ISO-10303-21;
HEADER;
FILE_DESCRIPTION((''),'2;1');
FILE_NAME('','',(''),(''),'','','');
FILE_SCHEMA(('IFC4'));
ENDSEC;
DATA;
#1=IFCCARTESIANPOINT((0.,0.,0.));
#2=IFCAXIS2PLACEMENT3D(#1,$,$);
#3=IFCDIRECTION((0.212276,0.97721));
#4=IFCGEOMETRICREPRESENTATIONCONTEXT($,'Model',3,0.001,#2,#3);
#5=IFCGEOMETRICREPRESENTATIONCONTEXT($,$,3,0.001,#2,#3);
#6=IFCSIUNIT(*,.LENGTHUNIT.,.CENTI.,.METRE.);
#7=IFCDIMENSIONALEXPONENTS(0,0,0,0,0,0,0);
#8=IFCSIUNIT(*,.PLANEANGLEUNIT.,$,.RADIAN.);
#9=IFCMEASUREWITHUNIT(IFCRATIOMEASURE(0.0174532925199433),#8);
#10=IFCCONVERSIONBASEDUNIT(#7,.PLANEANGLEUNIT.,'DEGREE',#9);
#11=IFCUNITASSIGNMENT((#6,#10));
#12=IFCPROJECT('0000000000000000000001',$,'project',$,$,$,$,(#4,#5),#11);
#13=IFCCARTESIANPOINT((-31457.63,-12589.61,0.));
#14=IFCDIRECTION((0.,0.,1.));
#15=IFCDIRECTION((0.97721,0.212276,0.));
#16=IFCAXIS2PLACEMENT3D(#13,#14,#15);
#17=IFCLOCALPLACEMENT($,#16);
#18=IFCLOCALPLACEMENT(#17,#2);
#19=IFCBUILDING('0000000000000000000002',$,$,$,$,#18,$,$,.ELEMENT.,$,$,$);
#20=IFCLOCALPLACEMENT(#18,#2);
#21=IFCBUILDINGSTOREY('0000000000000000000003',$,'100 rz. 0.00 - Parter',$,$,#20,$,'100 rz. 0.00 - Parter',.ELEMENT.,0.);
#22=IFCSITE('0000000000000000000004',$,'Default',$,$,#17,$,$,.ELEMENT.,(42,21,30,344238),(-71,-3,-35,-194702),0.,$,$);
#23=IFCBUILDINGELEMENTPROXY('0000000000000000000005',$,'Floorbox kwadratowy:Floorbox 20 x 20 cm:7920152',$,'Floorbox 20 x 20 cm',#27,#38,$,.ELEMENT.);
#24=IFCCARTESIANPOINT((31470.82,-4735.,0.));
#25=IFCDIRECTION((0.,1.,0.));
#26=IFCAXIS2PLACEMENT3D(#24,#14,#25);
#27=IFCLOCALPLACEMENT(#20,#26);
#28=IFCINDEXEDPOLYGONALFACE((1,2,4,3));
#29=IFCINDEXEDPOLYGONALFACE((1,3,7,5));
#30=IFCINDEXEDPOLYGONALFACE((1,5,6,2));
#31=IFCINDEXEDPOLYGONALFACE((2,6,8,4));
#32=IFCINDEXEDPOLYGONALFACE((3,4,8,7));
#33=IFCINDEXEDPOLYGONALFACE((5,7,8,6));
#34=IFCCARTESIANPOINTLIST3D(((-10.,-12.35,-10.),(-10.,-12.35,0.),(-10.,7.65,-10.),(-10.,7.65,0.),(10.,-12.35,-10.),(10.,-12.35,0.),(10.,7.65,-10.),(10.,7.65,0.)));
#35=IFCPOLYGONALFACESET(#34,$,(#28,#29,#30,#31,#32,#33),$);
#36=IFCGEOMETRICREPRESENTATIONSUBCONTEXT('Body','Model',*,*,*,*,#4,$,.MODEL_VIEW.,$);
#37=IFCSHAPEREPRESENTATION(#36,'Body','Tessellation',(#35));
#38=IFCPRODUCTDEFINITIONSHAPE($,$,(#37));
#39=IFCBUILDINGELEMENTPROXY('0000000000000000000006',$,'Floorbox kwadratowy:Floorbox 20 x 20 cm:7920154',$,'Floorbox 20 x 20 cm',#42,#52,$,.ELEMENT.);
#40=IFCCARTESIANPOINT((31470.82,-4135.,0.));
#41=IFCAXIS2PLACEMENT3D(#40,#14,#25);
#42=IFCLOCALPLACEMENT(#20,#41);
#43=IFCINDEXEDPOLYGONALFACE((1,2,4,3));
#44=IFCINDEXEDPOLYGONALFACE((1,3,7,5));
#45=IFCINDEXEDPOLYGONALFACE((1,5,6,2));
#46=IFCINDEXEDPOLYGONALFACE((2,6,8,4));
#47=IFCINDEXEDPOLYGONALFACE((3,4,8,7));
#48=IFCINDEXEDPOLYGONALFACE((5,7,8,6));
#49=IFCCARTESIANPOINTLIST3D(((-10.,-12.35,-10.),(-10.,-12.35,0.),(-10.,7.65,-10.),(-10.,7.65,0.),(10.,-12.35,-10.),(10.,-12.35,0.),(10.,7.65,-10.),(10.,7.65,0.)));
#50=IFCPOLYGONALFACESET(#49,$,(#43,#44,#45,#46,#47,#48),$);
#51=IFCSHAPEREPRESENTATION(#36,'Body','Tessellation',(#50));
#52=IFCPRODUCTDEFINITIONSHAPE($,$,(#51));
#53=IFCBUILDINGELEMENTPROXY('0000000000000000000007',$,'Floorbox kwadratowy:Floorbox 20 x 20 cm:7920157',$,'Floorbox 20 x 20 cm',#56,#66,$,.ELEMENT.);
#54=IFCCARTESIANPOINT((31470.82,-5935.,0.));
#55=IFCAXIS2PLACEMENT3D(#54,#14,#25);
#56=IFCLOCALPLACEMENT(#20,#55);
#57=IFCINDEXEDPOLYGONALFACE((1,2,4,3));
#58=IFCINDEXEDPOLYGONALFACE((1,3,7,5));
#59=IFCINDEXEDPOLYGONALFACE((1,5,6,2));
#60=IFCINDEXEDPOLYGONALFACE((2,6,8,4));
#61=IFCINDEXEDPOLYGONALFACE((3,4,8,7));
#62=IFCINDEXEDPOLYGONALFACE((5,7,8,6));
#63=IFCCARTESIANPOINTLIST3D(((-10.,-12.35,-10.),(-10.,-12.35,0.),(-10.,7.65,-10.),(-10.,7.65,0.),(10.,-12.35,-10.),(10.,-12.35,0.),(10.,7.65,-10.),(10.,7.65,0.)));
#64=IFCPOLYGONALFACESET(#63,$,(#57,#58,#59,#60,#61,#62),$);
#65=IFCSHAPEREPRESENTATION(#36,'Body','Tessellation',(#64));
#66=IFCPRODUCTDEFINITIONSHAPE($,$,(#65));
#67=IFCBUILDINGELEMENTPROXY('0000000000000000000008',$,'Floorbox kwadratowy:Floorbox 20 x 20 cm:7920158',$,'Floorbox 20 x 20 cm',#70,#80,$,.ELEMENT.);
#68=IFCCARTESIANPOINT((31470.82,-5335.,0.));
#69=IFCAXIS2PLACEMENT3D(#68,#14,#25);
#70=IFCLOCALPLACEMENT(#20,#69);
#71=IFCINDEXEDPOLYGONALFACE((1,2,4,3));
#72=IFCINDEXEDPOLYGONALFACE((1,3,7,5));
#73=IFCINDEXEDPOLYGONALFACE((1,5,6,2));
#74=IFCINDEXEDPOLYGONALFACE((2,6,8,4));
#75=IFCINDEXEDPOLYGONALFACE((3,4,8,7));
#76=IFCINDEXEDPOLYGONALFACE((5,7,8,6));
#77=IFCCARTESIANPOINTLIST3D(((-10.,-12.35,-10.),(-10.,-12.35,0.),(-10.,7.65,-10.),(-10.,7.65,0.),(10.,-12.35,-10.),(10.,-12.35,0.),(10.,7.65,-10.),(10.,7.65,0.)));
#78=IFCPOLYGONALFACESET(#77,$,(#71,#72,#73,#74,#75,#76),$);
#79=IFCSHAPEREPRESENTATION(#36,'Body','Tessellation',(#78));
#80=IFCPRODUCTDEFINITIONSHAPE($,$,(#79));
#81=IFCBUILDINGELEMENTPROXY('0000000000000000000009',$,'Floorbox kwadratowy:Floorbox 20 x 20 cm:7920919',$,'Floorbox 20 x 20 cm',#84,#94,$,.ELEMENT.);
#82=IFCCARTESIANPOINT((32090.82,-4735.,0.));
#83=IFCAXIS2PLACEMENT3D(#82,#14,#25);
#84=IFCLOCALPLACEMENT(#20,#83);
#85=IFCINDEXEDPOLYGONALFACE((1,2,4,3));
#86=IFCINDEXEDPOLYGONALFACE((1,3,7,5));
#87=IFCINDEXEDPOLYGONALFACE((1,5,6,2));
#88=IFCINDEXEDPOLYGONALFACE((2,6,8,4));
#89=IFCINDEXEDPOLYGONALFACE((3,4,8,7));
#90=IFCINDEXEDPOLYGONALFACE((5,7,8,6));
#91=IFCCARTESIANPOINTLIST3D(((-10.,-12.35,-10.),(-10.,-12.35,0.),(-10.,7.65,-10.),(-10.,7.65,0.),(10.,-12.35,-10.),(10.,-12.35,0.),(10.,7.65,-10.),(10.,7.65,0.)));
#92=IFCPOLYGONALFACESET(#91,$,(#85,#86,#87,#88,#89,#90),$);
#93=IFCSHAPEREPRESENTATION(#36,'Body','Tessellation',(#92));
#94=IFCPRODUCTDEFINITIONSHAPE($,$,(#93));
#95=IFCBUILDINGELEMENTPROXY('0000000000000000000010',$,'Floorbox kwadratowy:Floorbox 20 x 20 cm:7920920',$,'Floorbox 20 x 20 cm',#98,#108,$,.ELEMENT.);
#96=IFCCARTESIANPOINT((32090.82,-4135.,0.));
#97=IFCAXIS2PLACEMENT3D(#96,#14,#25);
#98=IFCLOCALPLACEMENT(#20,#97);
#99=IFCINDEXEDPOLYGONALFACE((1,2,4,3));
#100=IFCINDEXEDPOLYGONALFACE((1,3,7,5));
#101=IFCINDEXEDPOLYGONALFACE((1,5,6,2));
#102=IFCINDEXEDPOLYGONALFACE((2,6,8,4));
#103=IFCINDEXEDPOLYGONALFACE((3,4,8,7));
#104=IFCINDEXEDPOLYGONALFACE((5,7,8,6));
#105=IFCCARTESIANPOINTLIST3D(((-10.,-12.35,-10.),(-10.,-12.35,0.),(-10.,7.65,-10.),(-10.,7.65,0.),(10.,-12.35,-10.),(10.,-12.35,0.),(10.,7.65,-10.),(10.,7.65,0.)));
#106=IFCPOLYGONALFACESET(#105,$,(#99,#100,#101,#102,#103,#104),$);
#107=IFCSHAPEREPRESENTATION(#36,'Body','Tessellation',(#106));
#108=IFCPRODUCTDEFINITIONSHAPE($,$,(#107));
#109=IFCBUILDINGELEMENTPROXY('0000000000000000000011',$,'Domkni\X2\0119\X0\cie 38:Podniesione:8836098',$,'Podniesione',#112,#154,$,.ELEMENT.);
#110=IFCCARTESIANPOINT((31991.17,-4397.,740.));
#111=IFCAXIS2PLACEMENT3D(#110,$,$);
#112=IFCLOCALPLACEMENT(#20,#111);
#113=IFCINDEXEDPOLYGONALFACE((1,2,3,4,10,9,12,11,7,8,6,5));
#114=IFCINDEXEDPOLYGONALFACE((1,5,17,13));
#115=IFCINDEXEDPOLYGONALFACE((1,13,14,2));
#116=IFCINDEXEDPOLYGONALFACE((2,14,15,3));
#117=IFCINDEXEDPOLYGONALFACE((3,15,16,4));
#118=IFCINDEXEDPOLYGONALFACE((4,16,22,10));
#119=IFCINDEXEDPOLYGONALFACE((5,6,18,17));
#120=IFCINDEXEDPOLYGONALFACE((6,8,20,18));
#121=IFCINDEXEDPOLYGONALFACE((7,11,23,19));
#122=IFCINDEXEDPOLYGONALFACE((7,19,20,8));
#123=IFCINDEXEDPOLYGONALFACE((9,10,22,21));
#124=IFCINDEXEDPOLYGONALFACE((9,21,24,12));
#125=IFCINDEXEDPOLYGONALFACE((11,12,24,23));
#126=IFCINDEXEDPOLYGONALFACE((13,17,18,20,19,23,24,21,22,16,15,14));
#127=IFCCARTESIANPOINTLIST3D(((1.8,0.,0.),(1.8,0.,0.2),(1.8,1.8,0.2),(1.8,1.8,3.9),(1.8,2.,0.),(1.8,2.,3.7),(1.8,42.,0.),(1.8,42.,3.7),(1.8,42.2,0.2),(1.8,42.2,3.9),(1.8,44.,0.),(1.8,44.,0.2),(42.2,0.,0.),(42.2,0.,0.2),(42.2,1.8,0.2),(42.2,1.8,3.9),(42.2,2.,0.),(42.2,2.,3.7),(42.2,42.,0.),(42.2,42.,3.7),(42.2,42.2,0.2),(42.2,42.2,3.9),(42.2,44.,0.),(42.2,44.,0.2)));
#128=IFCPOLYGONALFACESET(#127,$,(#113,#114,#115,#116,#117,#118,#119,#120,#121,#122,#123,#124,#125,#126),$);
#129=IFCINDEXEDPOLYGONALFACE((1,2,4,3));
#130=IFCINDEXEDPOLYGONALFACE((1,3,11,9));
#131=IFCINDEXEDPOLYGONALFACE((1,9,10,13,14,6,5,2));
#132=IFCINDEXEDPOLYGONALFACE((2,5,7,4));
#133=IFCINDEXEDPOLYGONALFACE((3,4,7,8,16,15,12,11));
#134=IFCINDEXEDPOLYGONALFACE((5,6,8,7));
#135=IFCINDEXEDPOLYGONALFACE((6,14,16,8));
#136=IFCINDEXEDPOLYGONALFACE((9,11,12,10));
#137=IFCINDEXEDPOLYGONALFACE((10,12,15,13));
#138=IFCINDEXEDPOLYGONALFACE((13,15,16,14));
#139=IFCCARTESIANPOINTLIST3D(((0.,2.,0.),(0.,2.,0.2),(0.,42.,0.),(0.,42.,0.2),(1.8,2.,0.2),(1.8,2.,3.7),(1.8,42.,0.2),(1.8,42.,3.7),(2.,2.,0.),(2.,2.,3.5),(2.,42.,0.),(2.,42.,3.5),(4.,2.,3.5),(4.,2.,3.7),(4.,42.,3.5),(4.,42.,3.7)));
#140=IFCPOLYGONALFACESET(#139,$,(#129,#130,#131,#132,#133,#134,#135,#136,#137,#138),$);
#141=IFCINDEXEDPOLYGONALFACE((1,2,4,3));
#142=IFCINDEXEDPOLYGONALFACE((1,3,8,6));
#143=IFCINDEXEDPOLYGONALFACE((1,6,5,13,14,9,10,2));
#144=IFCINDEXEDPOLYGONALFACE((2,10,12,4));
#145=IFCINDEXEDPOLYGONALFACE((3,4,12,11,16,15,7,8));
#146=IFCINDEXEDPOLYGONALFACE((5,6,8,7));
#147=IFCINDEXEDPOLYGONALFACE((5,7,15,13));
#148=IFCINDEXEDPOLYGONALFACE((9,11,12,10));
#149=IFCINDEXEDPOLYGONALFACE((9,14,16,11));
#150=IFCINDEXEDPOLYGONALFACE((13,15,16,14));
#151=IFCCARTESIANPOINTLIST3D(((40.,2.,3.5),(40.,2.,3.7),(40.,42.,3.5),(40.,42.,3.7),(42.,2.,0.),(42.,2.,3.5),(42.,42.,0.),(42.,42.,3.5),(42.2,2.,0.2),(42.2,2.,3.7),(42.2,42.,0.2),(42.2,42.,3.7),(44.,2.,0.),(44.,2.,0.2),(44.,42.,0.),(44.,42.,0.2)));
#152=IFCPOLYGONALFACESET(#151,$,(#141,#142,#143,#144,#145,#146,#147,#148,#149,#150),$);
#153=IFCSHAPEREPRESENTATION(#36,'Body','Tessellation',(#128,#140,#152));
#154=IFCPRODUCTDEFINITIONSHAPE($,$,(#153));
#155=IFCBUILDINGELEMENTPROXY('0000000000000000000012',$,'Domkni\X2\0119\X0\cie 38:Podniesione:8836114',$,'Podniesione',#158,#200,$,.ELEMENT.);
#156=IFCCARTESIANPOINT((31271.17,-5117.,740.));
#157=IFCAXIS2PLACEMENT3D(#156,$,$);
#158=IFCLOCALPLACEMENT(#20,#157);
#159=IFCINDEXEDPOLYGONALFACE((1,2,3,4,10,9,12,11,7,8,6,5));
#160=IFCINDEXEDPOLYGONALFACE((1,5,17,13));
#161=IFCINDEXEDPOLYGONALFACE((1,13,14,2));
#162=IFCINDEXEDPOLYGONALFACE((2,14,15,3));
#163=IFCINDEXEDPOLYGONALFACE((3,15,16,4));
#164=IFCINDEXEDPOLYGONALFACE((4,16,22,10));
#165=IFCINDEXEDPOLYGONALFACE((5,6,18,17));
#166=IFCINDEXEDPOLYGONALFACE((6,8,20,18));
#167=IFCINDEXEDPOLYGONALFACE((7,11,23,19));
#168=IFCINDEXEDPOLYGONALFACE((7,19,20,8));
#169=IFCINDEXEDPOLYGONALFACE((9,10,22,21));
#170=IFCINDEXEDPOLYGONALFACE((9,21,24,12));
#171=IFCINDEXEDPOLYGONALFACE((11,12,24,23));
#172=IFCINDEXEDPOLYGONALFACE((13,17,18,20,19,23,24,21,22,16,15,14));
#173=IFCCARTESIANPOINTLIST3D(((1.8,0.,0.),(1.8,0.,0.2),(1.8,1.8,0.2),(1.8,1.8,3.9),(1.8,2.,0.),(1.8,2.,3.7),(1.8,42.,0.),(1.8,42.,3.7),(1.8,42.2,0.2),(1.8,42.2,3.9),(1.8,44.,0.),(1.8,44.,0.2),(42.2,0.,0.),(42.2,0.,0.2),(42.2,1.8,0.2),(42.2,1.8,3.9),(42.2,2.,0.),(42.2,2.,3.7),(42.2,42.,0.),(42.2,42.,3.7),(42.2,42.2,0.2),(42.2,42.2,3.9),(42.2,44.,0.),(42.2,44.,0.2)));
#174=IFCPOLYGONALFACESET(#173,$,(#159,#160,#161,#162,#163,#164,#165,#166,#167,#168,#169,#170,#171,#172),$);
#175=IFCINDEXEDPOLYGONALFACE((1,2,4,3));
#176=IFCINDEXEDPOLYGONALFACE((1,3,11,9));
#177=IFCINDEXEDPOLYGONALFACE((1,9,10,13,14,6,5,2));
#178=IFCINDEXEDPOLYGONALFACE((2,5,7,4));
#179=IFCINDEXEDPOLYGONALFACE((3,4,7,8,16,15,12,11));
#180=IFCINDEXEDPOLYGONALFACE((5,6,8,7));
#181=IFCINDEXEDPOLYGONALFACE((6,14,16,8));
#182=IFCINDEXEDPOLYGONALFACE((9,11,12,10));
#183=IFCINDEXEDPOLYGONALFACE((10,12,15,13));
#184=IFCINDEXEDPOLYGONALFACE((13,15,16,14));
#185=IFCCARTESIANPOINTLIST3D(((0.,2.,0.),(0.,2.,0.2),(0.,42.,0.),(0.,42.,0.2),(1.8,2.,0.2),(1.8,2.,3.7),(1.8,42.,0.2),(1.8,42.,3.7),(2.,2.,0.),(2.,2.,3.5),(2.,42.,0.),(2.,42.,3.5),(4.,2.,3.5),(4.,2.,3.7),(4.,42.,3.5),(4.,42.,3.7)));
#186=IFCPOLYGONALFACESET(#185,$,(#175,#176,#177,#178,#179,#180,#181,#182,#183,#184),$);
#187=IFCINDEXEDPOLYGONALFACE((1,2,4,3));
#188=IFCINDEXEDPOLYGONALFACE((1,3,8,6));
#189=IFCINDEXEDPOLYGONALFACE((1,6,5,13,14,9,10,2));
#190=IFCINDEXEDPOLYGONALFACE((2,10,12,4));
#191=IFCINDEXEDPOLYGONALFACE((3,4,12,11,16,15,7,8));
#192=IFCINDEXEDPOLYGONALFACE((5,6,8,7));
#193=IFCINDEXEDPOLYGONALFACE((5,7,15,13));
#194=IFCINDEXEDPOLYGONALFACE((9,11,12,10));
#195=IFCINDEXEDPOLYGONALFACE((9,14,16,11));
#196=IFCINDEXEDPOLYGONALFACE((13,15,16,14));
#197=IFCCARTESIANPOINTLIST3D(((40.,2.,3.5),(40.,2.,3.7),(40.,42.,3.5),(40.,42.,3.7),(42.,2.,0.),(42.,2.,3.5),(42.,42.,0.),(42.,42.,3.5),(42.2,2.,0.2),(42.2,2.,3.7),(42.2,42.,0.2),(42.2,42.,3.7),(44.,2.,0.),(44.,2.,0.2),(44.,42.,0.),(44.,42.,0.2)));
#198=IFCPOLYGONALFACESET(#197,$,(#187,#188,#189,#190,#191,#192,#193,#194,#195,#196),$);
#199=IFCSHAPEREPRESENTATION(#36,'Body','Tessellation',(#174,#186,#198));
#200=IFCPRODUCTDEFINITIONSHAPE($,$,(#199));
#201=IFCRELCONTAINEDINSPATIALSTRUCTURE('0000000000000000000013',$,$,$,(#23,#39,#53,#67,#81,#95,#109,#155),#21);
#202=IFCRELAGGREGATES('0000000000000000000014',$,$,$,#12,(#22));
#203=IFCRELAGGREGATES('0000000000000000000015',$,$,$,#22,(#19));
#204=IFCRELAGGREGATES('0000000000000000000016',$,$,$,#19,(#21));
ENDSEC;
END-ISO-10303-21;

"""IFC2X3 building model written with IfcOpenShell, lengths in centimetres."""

from ifc_helpers import new_model, entity, si_unit, converted_unit, direction, frame, origin, origin_2d_with_axis, place, context, subcontext, project, spatial, polyline, rectangle, outline, extrude, source, transform, mapped, element, save


model = new_model("IFC2X3")

# Units and contexts
model_context = context("Model", 3, precision=0.001, world=origin(), true_north=direction((0.212276, 0.97721)))
context_of_model = context(None, 3, precision=0.001, world=origin(), true_north=direction((0.212276, 0.97721)))
body_context = subcontext(model_context, "Body", "Model", "MODEL_VIEW")
ifc_project = project(units=[si_unit("LENGTHUNIT", "METRE", prefix="CENTI"), converted_unit("PLANEANGLEUNIT", "DEGREE", entity("IfcRatioMeasure", 0.0174532925199433), si_unit("PLANEANGLEUNIT", "RADIAN"), dimensions=[0, 0, 0, 0, 0, 0, 0])], contexts=[model_context, context_of_model])

# Site, building, storey
site_placement = place(None, frame((-31457.63, -12589.61, 0.0), z_axis=(0.0, 0.0, 1.0), x_axis=(0.97721, 0.212276, 0.0)))
site = spatial("IfcSite", under=ifc_project, at=site_placement, Name="Default", CompositionType="ELEMENT", RefLatitude=(42, 21, 30, 344238), RefLongitude=(-71, -3, -35, -194702), RefElevation=0.0)
building_placement = place(site_placement, origin())
building = spatial("IfcBuilding", under=site, at=building_placement, CompositionType="ELEMENT")
storey_placement = place(building_placement, origin())
storey = spatial("IfcBuildingStorey", under=building, at=storey_placement, Name="100 rz. 0.00 - Parter", LongName="100 rz. 0.00 - Parter", CompositionType="ELEMENT", Elevation=0.0)

# Building element proxies
shared_shape_1 = source(origin(), body_context, "Body", "SweptSolid", [
    extrude(rectangle(XDim=20.0, YDim=20.0, at=origin_2d_with_axis()), frame((0.0, -2.35, -10.0), z_axis=(0.0, 0.0, 1.0), x_axis=(-1.0, 0.0, 0.0)), (0.0, 0.0, 1.0), 10.0),
])
for number, where, z_axis, x_axis, name in (
    (1, (31470.82, -4735.0, 0.0), (0.0, 0.0, 1.0), (0.0, 1.0, 0.0), "Floorbox kwadratowy:Floorbox 20 x 20 cm:7920152"),
    (2, (31470.82, -4135.0, 0.0), (0.0, 0.0, 1.0), (0.0, 1.0, 0.0), "Floorbox kwadratowy:Floorbox 20 x 20 cm:7920154"),
    (3, (31470.82, -5935.0, 0.0), (0.0, 0.0, 1.0), (0.0, 1.0, 0.0), "Floorbox kwadratowy:Floorbox 20 x 20 cm:7920157"),
    (4, (31470.82, -5335.0, 0.0), (0.0, 0.0, 1.0), (0.0, 1.0, 0.0), "Floorbox kwadratowy:Floorbox 20 x 20 cm:7920158"),
    (5, (32090.82, -4735.0, 0.0), (0.0, 0.0, 1.0), (0.0, 1.0, 0.0), "Floorbox kwadratowy:Floorbox 20 x 20 cm:7920919"),
    (6, (32090.82, -4135.0, 0.0), (0.0, 0.0, 1.0), (0.0, 1.0, 0.0), "Floorbox kwadratowy:Floorbox 20 x 20 cm:7920920"),
):
    element("IfcBuildingElementProxy", number, at=place(storey_placement, frame(where, z_axis=z_axis, x_axis=x_axis)), inside=storey, Name=name, ObjectType="Floorbox 20 x 20 cm", CompositionType="ELEMENT", context=body_context, shape_type="MappedRepresentation", body=[
        mapped(shared_shape_1, transform((0.0, 0.0, 0.0), scale=1.0)),
    ])
shared_shape_2 = source(origin(), body_context, "Body", "SweptSolid", [
    extrude(outline(polyline([(-2.37, 20.0), (1.33, 20.0), (1.33, 22.0), (1.13, 22.0), (1.13, 20.2), (-2.57, 20.2), (-2.57, -20.2), (1.13, -20.2), (1.13, -22.0), (1.33, -22.0), (1.33, -20.0), (-2.37, -20.0), (-2.37, 20.0)])), frame((1.8, 22.0, 1.33), z_axis=(1.0, 0.0, 0.0), x_axis=(0.0, 0.0, -1.0)), (0.0, 0.0, 1.0), 40.4),
    extrude(outline(polyline([(-1.65, -0.05), (1.85, -0.05), (1.85, 1.95), (1.65, 1.95), (1.65, 0.15), (-1.85, 0.15), (-1.85, -2.05), (-1.65, -2.05), (-1.65, -0.05)])), frame((1.95, 2.0, 1.85), z_axis=(0.0, 1.0, 0.0), x_axis=(0.0, 0.0, -1.0)), (0.0, 0.0, 1.0), 40.0),
    extrude(outline(polyline([(0.05, 1.65), (2.05, 1.65), (2.05, 1.85), (-0.15, 1.85), (-0.15, -1.65), (-1.95, -1.65), (-1.95, -1.85), (0.05, -1.85), (0.05, 1.65)])), frame((42.05, 2.0, 1.85), z_axis=(0.0, 1.0, 0.0), x_axis=(-1.0, 0.0, 0.0)), (0.0, 0.0, 1.0), 40.0),
])
for number, where, name in (
    (7, (31991.17, -4397.0, 740.0), "Domknięcie 38:Podniesione:8836098"),
    (8, (31271.17, -5117.0, 740.0), "Domknięcie 38:Podniesione:8836114"),
):
    element("IfcBuildingElementProxy", number, at=place(storey_placement, frame(where)), inside=storey, Name=name, ObjectType="Podniesione", CompositionType="ELEMENT", context=body_context, shape_type="MappedRepresentation", body=[
        mapped(shared_shape_2, transform((0.0, 0.0, 0.0), scale=1.0)),
    ])

save(model, "model.ifc")
